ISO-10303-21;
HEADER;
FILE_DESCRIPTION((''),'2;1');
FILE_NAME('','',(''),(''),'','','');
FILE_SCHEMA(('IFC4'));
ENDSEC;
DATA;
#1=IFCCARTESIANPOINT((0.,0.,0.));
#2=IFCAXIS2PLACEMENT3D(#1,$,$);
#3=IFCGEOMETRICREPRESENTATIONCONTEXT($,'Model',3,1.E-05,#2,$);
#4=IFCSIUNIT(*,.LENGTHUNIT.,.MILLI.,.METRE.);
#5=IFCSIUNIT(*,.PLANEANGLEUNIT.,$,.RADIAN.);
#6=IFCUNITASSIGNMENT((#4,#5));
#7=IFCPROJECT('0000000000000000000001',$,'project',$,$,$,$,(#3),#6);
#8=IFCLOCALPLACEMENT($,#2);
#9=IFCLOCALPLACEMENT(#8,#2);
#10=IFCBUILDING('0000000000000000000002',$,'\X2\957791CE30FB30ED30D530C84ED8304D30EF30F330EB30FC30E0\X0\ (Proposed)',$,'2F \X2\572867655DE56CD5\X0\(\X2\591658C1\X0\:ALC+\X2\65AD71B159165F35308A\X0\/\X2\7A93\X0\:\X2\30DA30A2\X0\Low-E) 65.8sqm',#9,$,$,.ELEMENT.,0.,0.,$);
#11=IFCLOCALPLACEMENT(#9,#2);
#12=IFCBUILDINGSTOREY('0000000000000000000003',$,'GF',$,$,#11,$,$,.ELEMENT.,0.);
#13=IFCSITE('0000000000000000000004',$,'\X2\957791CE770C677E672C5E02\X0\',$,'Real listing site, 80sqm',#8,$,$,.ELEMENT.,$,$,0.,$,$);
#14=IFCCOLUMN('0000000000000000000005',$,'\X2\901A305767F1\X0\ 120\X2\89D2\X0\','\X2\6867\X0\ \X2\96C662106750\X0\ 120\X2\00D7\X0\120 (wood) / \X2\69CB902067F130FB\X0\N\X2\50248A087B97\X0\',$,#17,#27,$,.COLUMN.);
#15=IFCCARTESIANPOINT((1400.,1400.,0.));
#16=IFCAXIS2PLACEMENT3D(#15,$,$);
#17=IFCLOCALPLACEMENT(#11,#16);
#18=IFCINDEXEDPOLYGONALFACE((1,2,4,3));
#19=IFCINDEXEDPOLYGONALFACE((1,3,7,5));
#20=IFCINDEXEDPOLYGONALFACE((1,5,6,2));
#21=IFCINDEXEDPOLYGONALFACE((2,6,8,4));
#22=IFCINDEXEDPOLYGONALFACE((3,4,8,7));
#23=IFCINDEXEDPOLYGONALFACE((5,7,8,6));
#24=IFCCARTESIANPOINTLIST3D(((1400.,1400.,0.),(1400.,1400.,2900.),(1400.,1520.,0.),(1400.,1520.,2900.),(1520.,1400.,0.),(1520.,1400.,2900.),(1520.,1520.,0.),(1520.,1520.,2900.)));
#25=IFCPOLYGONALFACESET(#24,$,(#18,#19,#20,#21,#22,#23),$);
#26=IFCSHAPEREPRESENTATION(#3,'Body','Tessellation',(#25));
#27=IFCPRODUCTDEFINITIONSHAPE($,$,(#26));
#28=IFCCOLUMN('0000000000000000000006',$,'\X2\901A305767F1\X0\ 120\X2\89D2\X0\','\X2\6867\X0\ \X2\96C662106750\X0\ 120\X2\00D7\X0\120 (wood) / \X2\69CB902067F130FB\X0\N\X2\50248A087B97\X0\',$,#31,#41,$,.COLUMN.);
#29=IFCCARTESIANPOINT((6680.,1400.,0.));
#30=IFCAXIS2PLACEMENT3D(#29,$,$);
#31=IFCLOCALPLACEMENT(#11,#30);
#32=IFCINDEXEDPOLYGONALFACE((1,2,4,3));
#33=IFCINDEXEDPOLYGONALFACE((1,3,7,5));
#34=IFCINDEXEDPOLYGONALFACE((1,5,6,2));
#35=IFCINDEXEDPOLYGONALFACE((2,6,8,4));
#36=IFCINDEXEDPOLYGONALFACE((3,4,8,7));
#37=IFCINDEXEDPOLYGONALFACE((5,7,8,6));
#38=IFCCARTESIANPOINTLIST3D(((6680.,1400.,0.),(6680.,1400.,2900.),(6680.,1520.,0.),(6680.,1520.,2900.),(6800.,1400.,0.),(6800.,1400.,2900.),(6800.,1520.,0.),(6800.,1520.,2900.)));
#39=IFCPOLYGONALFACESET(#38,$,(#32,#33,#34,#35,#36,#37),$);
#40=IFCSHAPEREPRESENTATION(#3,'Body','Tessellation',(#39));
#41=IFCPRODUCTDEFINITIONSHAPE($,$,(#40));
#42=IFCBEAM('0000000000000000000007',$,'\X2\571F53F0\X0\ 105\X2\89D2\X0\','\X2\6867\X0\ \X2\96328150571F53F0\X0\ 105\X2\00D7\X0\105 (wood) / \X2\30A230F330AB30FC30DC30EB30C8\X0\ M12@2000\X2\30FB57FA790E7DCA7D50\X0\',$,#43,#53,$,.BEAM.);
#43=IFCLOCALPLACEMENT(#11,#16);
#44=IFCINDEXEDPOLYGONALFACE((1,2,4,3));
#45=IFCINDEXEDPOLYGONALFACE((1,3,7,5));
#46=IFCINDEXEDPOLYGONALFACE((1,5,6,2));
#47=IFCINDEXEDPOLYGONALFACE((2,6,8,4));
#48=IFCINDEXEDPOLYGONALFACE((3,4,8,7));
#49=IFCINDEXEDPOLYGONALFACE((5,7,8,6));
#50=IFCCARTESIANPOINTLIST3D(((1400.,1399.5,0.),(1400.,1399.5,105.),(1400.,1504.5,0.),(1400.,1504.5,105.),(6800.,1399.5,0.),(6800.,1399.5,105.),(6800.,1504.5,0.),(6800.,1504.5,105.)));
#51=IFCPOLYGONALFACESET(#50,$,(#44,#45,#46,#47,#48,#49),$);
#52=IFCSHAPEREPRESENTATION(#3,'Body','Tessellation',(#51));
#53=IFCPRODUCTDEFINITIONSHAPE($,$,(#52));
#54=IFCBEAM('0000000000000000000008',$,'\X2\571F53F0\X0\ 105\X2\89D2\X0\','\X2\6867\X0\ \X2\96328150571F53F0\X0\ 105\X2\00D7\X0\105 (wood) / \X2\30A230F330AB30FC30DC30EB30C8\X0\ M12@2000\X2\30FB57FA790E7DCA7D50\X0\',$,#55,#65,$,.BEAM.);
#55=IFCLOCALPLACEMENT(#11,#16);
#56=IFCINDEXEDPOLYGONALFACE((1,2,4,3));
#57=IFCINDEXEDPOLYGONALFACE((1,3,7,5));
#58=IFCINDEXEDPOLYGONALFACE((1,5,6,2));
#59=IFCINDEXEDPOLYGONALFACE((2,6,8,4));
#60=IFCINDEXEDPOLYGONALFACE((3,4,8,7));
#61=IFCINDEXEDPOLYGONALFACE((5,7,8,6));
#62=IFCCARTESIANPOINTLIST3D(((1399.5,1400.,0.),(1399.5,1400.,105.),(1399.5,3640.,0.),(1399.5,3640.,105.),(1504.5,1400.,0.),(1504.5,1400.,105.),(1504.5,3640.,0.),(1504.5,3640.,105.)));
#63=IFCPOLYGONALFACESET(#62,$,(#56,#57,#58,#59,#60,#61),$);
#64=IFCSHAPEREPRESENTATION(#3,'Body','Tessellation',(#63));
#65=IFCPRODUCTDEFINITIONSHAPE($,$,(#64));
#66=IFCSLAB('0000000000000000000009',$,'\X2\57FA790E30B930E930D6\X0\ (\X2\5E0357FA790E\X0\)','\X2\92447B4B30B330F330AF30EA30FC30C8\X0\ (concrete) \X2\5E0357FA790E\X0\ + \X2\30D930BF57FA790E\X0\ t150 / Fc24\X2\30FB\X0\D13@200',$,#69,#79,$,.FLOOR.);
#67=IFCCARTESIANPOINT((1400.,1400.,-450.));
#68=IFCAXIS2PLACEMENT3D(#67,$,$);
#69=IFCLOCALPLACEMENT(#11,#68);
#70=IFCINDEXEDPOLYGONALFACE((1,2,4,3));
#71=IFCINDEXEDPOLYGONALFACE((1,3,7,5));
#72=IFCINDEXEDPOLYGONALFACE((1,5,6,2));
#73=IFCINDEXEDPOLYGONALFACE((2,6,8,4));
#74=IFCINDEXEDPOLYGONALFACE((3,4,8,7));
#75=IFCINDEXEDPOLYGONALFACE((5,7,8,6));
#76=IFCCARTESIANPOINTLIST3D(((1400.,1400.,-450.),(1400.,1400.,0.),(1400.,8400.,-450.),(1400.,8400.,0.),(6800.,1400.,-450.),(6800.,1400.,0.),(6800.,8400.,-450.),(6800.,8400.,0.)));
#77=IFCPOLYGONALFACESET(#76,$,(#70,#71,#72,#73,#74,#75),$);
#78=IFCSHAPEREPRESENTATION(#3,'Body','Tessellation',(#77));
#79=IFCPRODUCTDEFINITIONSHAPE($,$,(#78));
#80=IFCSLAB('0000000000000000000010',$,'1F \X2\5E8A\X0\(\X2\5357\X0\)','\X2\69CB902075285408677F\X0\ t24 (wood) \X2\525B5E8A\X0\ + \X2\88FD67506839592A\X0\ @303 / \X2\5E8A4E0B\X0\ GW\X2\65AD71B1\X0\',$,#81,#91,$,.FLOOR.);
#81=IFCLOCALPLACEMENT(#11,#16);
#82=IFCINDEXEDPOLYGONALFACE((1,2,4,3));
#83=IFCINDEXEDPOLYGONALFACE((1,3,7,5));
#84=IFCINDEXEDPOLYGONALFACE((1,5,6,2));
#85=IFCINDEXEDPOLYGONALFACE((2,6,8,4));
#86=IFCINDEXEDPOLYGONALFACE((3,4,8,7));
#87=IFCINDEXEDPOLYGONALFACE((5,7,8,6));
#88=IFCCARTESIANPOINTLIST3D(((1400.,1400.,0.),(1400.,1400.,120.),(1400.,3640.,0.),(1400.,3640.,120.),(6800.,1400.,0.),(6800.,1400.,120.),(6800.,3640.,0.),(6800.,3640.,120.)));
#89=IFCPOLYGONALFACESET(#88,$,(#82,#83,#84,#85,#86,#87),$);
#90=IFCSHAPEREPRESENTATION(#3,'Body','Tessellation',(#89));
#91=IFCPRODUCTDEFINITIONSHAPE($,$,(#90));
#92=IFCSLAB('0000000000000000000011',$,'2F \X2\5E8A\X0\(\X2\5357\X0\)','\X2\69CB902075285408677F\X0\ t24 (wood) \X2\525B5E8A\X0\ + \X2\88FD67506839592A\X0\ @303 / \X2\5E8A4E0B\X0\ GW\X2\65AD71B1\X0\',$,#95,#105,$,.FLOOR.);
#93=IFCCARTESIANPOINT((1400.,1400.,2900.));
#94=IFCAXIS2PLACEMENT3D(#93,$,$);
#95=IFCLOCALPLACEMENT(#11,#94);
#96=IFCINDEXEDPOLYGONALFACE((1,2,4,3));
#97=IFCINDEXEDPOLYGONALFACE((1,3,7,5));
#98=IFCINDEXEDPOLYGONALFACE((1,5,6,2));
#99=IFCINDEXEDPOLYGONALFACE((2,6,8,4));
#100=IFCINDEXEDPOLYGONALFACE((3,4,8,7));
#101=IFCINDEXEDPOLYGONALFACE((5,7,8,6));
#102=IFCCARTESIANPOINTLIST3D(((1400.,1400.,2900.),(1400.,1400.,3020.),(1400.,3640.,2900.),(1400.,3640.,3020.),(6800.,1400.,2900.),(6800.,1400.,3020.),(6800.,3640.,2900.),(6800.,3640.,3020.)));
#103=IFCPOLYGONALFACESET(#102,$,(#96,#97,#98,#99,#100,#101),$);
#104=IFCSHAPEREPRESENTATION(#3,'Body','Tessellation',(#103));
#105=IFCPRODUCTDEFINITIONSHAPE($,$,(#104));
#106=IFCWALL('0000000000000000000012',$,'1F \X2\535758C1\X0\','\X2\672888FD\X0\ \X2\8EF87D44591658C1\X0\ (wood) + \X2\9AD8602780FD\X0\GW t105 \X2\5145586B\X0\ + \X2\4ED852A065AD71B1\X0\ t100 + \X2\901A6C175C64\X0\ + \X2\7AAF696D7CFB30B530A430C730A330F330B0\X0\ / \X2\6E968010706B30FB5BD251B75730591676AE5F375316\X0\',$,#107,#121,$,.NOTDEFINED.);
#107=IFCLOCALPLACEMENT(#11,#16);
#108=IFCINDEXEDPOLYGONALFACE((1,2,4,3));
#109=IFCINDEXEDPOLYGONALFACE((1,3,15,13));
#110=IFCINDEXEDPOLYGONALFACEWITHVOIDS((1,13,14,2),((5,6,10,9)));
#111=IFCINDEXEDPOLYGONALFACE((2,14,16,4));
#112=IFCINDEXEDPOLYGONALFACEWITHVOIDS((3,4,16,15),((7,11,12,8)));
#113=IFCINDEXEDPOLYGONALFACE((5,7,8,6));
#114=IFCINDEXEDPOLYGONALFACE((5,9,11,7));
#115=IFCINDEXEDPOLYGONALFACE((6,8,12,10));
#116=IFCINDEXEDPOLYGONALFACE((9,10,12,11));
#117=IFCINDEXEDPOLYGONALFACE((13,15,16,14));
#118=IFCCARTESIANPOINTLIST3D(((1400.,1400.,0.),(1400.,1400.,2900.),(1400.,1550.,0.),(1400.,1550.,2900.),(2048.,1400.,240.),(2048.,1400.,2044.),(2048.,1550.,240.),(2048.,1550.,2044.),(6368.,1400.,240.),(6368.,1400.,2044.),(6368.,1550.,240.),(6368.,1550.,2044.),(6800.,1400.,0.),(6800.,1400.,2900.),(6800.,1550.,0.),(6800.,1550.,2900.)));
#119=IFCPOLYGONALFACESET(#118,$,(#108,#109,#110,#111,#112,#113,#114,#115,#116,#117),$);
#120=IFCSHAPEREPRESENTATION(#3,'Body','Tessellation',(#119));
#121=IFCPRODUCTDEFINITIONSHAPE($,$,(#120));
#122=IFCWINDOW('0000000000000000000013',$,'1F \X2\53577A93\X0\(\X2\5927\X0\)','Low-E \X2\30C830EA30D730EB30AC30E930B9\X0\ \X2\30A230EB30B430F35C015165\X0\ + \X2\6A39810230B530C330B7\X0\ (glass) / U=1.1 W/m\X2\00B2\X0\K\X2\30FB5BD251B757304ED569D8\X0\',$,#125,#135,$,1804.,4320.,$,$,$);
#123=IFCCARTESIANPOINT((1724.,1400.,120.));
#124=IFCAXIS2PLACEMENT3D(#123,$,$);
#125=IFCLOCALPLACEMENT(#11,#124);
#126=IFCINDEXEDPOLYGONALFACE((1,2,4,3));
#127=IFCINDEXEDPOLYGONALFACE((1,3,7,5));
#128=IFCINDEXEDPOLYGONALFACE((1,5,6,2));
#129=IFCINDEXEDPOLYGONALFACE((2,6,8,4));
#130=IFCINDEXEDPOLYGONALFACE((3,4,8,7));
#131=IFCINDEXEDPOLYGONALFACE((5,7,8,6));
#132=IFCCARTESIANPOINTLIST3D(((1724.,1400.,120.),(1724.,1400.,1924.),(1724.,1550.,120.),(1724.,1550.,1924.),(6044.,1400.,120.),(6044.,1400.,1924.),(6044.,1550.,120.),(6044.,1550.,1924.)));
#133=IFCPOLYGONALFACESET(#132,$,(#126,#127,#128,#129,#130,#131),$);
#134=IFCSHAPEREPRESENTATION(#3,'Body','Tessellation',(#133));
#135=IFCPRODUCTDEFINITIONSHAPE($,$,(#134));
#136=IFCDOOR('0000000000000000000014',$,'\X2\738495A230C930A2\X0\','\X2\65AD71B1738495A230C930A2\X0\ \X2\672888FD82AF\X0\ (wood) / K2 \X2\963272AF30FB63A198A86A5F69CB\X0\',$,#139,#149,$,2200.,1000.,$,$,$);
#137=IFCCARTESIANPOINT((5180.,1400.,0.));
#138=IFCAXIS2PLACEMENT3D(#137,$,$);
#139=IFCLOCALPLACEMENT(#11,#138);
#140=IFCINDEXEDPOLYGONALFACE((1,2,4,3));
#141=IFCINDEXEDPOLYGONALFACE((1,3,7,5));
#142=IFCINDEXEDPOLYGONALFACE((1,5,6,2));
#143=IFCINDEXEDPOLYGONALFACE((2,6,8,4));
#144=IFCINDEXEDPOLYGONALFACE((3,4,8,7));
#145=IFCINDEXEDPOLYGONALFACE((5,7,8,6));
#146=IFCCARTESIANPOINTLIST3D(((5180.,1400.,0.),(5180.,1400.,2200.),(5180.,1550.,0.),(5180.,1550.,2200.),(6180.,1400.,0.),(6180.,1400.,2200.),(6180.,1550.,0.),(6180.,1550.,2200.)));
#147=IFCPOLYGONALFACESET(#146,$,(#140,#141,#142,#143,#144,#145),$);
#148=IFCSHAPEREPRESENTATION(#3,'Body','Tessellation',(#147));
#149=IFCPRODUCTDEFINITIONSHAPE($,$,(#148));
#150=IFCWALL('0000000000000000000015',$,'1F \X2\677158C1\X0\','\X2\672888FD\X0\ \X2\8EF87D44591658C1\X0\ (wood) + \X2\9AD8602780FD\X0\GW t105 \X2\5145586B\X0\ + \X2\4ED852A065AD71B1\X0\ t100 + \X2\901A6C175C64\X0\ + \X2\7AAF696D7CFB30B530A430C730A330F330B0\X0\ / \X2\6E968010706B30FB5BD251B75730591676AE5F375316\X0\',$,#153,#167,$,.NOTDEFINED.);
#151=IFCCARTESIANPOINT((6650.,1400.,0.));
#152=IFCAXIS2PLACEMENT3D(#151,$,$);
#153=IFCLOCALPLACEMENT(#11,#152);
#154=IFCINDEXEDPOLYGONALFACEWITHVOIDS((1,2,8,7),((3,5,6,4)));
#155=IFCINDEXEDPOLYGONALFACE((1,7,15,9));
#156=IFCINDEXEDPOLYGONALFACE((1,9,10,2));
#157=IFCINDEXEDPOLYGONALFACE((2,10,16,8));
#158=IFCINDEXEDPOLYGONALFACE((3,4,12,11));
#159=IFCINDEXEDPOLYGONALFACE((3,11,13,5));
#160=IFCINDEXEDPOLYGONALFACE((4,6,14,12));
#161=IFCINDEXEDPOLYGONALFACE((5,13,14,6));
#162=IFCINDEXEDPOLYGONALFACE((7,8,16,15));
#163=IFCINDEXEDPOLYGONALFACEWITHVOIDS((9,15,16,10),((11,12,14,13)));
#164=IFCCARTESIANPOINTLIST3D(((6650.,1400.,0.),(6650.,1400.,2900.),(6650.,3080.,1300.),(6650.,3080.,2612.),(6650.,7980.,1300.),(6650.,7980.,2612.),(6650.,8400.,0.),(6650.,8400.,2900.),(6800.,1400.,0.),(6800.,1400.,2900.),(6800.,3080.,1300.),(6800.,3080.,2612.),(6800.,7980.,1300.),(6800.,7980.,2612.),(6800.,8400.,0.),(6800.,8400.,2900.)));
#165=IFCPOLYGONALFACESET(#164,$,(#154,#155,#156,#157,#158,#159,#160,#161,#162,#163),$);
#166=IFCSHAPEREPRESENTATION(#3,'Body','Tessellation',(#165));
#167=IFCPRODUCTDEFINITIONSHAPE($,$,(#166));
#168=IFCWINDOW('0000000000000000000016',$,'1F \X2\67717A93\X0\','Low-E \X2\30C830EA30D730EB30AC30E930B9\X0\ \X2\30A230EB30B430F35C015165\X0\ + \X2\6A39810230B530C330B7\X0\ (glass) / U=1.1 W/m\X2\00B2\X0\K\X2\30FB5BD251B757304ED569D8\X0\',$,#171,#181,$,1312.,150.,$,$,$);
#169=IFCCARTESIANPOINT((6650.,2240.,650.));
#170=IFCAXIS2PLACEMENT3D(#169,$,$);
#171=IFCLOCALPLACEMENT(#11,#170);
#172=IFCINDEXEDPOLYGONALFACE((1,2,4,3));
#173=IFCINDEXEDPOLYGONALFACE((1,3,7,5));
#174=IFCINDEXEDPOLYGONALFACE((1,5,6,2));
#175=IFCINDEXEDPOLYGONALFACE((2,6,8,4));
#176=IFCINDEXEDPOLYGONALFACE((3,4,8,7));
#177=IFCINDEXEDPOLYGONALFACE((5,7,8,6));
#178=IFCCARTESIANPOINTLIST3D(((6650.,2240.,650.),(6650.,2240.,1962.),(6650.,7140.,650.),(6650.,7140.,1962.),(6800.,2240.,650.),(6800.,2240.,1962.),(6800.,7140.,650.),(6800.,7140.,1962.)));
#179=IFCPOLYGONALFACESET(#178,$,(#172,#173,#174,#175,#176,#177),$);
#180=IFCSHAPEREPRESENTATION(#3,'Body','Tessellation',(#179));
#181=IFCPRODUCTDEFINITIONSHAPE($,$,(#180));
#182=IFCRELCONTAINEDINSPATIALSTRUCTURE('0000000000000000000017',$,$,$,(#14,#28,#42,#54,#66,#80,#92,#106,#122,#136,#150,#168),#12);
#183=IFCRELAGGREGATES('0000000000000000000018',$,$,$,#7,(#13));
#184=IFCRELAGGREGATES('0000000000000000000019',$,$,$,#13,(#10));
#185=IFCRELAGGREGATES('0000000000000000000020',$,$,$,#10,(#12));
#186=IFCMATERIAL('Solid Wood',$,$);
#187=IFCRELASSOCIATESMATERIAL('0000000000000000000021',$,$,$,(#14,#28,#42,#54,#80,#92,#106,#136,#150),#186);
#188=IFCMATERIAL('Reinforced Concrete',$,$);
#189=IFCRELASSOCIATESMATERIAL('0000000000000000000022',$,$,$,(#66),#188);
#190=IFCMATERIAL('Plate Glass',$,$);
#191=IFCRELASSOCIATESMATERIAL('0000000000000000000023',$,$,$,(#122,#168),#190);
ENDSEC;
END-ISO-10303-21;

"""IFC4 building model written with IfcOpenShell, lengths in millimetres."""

from ifc_helpers import new_model, si_unit, frame, frame_2d, origin, place, context, project, spatial, rectangle, extrude, material, element, fill, save


model = new_model("IFC4")

# Units and contexts
model_context = context("Model", 3, precision=1e-05, world=origin())
ifc_project = project(units=[si_unit("LENGTHUNIT", "METRE", prefix="MILLI"), si_unit("PLANEANGLEUNIT", "RADIAN")], contexts=[model_context])

# Site, building, storey
site_placement = place(None, origin())
site = spatial("IfcSite", under=ifc_project, at=site_placement, Name="長野県松本市", ObjectType="Real listing site, 80sqm", CompositionType="ELEMENT", RefElevation=0.0)
building_placement = place(site_placement, origin())
building = spatial("IfcBuilding", under=site, at=building_placement, Name="長野・ロフト付きワンルーム (Proposed)", ObjectType="2F 在来工法(外壁:ALC+断熱外張り/窓:ペアLow-E) 65.8sqm", CompositionType="ELEMENT", ElevationOfRefHeight=0.0, ElevationOfTerrain=0.0)
storey_placement = place(building_placement, origin())
storey = spatial("IfcBuildingStorey", under=building, at=storey_placement, Name="GF", CompositionType="ELEMENT", Elevation=0.0)

# Columns
ifc_material_1 = material(Name="Solid Wood")
column_1_placement = place(storey_placement, frame((1400.0, 1400.0, 0.0)))
element("IfcColumn", 1, at=column_1_placement, inside=storey, material=ifc_material_1, Name="通し柱 120角", Description="桧 集成材 120×120 (wood) / 構造柱・N値計算", PredefinedType="COLUMN", context=model_context, shape_type="SweptSolid", body=[
    extrude(rectangle(XDim=120.0, YDim=120.0, at=frame_2d((60.0, 60.0))), frame((1400.0, 1400.0, 0.0)), (0.0, 0.0, 1.0), 2900.0),
])
column_2_placement = place(storey_placement, frame((6680.0, 1400.0, 0.0)))
element("IfcColumn", 2, at=column_2_placement, inside=storey, material=ifc_material_1, Name="通し柱 120角", Description="桧 集成材 120×120 (wood) / 構造柱・N値計算", PredefinedType="COLUMN", context=model_context, shape_type="SweptSolid", body=[
    extrude(rectangle(XDim=120.0, YDim=120.0, at=frame_2d((60.0, 60.0))), frame((6680.0, 1400.0, 0.0)), (0.0, 0.0, 1.0), 2900.0),
])

# Beams
beam_1_placement = place(storey_placement, frame((1400.0, 1400.0, 0.0)))
element("IfcBeam", 3, at=beam_1_placement, inside=storey, material=ifc_material_1, Name="土台 105角", Description="桧 防腐土台 105×105 (wood) / アンカーボルト M12@2000・基礎緊結", PredefinedType="BEAM", context=model_context, shape_type="SweptSolid", body=[
    extrude(rectangle(XDim=5400.0, YDim=105.0, at=frame_2d((2700.0, 52.0))), frame((1400.0, 1400.0, 0.0)), (0.0, 0.0, 1.0), 105.0),
])
beam_2_placement = place(storey_placement, frame((1400.0, 1400.0, 0.0)))
element("IfcBeam", 4, at=beam_2_placement, inside=storey, material=ifc_material_1, Name="土台 105角", Description="桧 防腐土台 105×105 (wood) / アンカーボルト M12@2000・基礎緊結", PredefinedType="BEAM", context=model_context, shape_type="SweptSolid", body=[
    extrude(rectangle(XDim=105.0, YDim=2240.0, at=frame_2d((52.0, 1120.0))), frame((1400.0, 1400.0, 0.0)), (0.0, 0.0, 1.0), 105.0),
])

# Slabs
ifc_material_2 = material(Name="Reinforced Concrete")
slab_1_placement = place(storey_placement, frame((1400.0, 1400.0, -450.0)))
element("IfcSlab", 5, at=slab_1_placement, inside=storey, material=ifc_material_2, Name="基礎スラブ (布基礎)", Description="鉄筋コンクリート (concrete) 布基礎 + ベタ基礎 t150 / Fc24・D13@200", PredefinedType="FLOOR", context=model_context, shape_type="SweptSolid", body=[
    extrude(rectangle(XDim=5400.0, YDim=7000.0, at=frame_2d((2700.0, 3500.0))), frame((1400.0, 1400.0, -450.0)), (0.0, 0.0, 1.0), 450.0),
])
slab_2_placement = place(storey_placement, frame((1400.0, 1400.0, 0.0)))
element("IfcSlab", 6, at=slab_2_placement, inside=storey, material=ifc_material_1, Name="1F 床(南)", Description="構造用合板 t24 (wood) 剛床 + 製材根太 @303 / 床下 GW断熱", PredefinedType="FLOOR", context=model_context, shape_type="SweptSolid", body=[
    extrude(rectangle(XDim=5400.0, YDim=2240.0, at=frame_2d((2700.0, 1120.0))), frame((1400.0, 1400.0, 0.0)), (0.0, 0.0, 1.0), 120.0),
])
slab_3_placement = place(storey_placement, frame((1400.0, 1400.0, 2900.0)))
element("IfcSlab", 7, at=slab_3_placement, inside=storey, material=ifc_material_1, Name="2F 床(南)", Description="構造用合板 t24 (wood) 剛床 + 製材根太 @303 / 床下 GW断熱", PredefinedType="FLOOR", context=model_context, shape_type="SweptSolid", body=[
    extrude(rectangle(XDim=5400.0, YDim=2240.0, at=frame_2d((2700.0, 1120.0))), frame((1400.0, 1400.0, 2900.0)), (0.0, 0.0, 1.0), 120.0),
])

# Wall, openings, window, door
wall_1_placement = place(storey_placement, frame((1400.0, 1400.0, 0.0)))
wall_1 = element("IfcWall", 8, at=wall_1_placement, inside=storey, material=ifc_material_1, Name="1F 南壁", Description="木製 軸組外壁 (wood) + 高性能GW t105 充填 + 付加断熱 t100 + 通気層 + 窯業系サイディング / 準耐火・寒冷地外皮強化", PredefinedType="NOTDEFINED", context=model_context, shape_type="SweptSolid", body=[
    extrude(rectangle(XDim=5400.0, YDim=150.0, at=frame_2d((2700.0, 75.0))), frame((1400.0, 1400.0, 0.0)), (0.0, 0.0, 1.0), 2900.0),
])
opening_1_placement = place(storey_placement, frame((1724.0, 1400.0, 120.0)))
opening_1 = element("IfcOpeningElement", 9, at=opening_1_placement, cuts=wall_1, PredefinedType="NOTDEFINED", context=model_context, shape_type="SweptSolid", body=[
    extrude(rectangle(XDim=4320.0, YDim=150.0, at=frame_2d((2160.0, 75.0))), frame((1724.0, 1400.0, 120.0)), (0.0, 0.0, 1.0), 1804.0),
])
opening_2_placement = place(storey_placement, frame((5180.0, 1400.0, 0.0)))
opening_2 = element("IfcOpeningElement", 10, at=opening_2_placement, cuts=wall_1, PredefinedType="NOTDEFINED", context=model_context, shape_type="SweptSolid", body=[
    extrude(rectangle(XDim=1000.0, YDim=150.0, at=frame_2d((500.0, 75.0))), frame((5180.0, 1400.0, 0.0)), (0.0, 0.0, 1.0), 2200.0),
])
ifc_material_3 = material(Name="Plate Glass")
window_1_placement = place(storey_placement, frame((1724.0, 1400.0, 120.0)))
window_1 = element("IfcWindow", 11, at=window_1_placement, inside=storey, material=ifc_material_3, Name="1F 南窓(大)", Description="Low-E トリプルガラス アルゴン封入 + 樹脂サッシ (glass) / U=1.1 W/m²K・寒冷地仕様", OverallHeight=1804.0, OverallWidth=4320.0, context=model_context, shape_type="SweptSolid", body=[
    extrude(rectangle(XDim=4320.0, YDim=150.0, at=frame_2d((2160.0, 75.0))), frame((1724.0, 1400.0, 120.0)), (0.0, 0.0, 1.0), 1804.0),
])
fill(opening_1, window_1)
door_placement = place(storey_placement, frame((5180.0, 1400.0, 0.0)))
door = element("IfcDoor", 12, at=door_placement, inside=storey, material=ifc_material_1, Name="玄関ドア", Description="断熱玄関ドア 木製芯 (wood) / K2 防犯・採風機構", OverallHeight=2200.0, OverallWidth=1000.0, context=model_context, shape_type="SweptSolid", body=[
    extrude(rectangle(XDim=1000.0, YDim=150.0, at=frame_2d((500.0, 75.0))), frame((5180.0, 1400.0, 0.0)), (0.0, 0.0, 1.0), 2200.0),
])
fill(opening_2, door)

# Wall, opening, window
wall_2_placement = place(storey_placement, frame((6650.0, 1400.0, 0.0)))
wall_2 = element("IfcWall", 13, at=wall_2_placement, inside=storey, material=ifc_material_1, Name="1F 東壁", Description="木製 軸組外壁 (wood) + 高性能GW t105 充填 + 付加断熱 t100 + 通気層 + 窯業系サイディング / 準耐火・寒冷地外皮強化", PredefinedType="NOTDEFINED", context=model_context, shape_type="SweptSolid", body=[
    extrude(rectangle(XDim=150.0, YDim=7000.0, at=frame_2d((75.0, 3500.0))), frame((6650.0, 1400.0, 0.0)), (0.0, 0.0, 1.0), 2900.0),
])
opening_3_placement = place(storey_placement, frame((6650.0, 2240.0, 650.0)))
opening_3 = element("IfcOpeningElement", 14, at=opening_3_placement, cuts=wall_2, PredefinedType="NOTDEFINED", context=model_context, shape_type="SweptSolid", body=[
    extrude(rectangle(XDim=150.0, YDim=4900.0, at=frame_2d((75.0, 2450.0))), frame((6650.0, 2240.0, 650.0)), (0.0, 0.0, 1.0), 1312.0),
])
window_2_placement = place(storey_placement, frame((6650.0, 2240.0, 650.0)))
window_2 = element("IfcWindow", 15, at=window_2_placement, inside=storey, material=ifc_material_3, Name="1F 東窓", Description="Low-E トリプルガラス アルゴン封入 + 樹脂サッシ (glass) / U=1.1 W/m²K・寒冷地仕様", OverallHeight=1312.0, OverallWidth=150.0, context=model_context, shape_type="SweptSolid", body=[
    extrude(rectangle(XDim=150.0, YDim=4900.0, at=frame_2d((75.0, 2450.0))), frame((6650.0, 2240.0, 650.0)), (0.0, 0.0, 1.0), 1312.0),
])
fill(opening_3, window_2)

save(model, "model.ifc")
